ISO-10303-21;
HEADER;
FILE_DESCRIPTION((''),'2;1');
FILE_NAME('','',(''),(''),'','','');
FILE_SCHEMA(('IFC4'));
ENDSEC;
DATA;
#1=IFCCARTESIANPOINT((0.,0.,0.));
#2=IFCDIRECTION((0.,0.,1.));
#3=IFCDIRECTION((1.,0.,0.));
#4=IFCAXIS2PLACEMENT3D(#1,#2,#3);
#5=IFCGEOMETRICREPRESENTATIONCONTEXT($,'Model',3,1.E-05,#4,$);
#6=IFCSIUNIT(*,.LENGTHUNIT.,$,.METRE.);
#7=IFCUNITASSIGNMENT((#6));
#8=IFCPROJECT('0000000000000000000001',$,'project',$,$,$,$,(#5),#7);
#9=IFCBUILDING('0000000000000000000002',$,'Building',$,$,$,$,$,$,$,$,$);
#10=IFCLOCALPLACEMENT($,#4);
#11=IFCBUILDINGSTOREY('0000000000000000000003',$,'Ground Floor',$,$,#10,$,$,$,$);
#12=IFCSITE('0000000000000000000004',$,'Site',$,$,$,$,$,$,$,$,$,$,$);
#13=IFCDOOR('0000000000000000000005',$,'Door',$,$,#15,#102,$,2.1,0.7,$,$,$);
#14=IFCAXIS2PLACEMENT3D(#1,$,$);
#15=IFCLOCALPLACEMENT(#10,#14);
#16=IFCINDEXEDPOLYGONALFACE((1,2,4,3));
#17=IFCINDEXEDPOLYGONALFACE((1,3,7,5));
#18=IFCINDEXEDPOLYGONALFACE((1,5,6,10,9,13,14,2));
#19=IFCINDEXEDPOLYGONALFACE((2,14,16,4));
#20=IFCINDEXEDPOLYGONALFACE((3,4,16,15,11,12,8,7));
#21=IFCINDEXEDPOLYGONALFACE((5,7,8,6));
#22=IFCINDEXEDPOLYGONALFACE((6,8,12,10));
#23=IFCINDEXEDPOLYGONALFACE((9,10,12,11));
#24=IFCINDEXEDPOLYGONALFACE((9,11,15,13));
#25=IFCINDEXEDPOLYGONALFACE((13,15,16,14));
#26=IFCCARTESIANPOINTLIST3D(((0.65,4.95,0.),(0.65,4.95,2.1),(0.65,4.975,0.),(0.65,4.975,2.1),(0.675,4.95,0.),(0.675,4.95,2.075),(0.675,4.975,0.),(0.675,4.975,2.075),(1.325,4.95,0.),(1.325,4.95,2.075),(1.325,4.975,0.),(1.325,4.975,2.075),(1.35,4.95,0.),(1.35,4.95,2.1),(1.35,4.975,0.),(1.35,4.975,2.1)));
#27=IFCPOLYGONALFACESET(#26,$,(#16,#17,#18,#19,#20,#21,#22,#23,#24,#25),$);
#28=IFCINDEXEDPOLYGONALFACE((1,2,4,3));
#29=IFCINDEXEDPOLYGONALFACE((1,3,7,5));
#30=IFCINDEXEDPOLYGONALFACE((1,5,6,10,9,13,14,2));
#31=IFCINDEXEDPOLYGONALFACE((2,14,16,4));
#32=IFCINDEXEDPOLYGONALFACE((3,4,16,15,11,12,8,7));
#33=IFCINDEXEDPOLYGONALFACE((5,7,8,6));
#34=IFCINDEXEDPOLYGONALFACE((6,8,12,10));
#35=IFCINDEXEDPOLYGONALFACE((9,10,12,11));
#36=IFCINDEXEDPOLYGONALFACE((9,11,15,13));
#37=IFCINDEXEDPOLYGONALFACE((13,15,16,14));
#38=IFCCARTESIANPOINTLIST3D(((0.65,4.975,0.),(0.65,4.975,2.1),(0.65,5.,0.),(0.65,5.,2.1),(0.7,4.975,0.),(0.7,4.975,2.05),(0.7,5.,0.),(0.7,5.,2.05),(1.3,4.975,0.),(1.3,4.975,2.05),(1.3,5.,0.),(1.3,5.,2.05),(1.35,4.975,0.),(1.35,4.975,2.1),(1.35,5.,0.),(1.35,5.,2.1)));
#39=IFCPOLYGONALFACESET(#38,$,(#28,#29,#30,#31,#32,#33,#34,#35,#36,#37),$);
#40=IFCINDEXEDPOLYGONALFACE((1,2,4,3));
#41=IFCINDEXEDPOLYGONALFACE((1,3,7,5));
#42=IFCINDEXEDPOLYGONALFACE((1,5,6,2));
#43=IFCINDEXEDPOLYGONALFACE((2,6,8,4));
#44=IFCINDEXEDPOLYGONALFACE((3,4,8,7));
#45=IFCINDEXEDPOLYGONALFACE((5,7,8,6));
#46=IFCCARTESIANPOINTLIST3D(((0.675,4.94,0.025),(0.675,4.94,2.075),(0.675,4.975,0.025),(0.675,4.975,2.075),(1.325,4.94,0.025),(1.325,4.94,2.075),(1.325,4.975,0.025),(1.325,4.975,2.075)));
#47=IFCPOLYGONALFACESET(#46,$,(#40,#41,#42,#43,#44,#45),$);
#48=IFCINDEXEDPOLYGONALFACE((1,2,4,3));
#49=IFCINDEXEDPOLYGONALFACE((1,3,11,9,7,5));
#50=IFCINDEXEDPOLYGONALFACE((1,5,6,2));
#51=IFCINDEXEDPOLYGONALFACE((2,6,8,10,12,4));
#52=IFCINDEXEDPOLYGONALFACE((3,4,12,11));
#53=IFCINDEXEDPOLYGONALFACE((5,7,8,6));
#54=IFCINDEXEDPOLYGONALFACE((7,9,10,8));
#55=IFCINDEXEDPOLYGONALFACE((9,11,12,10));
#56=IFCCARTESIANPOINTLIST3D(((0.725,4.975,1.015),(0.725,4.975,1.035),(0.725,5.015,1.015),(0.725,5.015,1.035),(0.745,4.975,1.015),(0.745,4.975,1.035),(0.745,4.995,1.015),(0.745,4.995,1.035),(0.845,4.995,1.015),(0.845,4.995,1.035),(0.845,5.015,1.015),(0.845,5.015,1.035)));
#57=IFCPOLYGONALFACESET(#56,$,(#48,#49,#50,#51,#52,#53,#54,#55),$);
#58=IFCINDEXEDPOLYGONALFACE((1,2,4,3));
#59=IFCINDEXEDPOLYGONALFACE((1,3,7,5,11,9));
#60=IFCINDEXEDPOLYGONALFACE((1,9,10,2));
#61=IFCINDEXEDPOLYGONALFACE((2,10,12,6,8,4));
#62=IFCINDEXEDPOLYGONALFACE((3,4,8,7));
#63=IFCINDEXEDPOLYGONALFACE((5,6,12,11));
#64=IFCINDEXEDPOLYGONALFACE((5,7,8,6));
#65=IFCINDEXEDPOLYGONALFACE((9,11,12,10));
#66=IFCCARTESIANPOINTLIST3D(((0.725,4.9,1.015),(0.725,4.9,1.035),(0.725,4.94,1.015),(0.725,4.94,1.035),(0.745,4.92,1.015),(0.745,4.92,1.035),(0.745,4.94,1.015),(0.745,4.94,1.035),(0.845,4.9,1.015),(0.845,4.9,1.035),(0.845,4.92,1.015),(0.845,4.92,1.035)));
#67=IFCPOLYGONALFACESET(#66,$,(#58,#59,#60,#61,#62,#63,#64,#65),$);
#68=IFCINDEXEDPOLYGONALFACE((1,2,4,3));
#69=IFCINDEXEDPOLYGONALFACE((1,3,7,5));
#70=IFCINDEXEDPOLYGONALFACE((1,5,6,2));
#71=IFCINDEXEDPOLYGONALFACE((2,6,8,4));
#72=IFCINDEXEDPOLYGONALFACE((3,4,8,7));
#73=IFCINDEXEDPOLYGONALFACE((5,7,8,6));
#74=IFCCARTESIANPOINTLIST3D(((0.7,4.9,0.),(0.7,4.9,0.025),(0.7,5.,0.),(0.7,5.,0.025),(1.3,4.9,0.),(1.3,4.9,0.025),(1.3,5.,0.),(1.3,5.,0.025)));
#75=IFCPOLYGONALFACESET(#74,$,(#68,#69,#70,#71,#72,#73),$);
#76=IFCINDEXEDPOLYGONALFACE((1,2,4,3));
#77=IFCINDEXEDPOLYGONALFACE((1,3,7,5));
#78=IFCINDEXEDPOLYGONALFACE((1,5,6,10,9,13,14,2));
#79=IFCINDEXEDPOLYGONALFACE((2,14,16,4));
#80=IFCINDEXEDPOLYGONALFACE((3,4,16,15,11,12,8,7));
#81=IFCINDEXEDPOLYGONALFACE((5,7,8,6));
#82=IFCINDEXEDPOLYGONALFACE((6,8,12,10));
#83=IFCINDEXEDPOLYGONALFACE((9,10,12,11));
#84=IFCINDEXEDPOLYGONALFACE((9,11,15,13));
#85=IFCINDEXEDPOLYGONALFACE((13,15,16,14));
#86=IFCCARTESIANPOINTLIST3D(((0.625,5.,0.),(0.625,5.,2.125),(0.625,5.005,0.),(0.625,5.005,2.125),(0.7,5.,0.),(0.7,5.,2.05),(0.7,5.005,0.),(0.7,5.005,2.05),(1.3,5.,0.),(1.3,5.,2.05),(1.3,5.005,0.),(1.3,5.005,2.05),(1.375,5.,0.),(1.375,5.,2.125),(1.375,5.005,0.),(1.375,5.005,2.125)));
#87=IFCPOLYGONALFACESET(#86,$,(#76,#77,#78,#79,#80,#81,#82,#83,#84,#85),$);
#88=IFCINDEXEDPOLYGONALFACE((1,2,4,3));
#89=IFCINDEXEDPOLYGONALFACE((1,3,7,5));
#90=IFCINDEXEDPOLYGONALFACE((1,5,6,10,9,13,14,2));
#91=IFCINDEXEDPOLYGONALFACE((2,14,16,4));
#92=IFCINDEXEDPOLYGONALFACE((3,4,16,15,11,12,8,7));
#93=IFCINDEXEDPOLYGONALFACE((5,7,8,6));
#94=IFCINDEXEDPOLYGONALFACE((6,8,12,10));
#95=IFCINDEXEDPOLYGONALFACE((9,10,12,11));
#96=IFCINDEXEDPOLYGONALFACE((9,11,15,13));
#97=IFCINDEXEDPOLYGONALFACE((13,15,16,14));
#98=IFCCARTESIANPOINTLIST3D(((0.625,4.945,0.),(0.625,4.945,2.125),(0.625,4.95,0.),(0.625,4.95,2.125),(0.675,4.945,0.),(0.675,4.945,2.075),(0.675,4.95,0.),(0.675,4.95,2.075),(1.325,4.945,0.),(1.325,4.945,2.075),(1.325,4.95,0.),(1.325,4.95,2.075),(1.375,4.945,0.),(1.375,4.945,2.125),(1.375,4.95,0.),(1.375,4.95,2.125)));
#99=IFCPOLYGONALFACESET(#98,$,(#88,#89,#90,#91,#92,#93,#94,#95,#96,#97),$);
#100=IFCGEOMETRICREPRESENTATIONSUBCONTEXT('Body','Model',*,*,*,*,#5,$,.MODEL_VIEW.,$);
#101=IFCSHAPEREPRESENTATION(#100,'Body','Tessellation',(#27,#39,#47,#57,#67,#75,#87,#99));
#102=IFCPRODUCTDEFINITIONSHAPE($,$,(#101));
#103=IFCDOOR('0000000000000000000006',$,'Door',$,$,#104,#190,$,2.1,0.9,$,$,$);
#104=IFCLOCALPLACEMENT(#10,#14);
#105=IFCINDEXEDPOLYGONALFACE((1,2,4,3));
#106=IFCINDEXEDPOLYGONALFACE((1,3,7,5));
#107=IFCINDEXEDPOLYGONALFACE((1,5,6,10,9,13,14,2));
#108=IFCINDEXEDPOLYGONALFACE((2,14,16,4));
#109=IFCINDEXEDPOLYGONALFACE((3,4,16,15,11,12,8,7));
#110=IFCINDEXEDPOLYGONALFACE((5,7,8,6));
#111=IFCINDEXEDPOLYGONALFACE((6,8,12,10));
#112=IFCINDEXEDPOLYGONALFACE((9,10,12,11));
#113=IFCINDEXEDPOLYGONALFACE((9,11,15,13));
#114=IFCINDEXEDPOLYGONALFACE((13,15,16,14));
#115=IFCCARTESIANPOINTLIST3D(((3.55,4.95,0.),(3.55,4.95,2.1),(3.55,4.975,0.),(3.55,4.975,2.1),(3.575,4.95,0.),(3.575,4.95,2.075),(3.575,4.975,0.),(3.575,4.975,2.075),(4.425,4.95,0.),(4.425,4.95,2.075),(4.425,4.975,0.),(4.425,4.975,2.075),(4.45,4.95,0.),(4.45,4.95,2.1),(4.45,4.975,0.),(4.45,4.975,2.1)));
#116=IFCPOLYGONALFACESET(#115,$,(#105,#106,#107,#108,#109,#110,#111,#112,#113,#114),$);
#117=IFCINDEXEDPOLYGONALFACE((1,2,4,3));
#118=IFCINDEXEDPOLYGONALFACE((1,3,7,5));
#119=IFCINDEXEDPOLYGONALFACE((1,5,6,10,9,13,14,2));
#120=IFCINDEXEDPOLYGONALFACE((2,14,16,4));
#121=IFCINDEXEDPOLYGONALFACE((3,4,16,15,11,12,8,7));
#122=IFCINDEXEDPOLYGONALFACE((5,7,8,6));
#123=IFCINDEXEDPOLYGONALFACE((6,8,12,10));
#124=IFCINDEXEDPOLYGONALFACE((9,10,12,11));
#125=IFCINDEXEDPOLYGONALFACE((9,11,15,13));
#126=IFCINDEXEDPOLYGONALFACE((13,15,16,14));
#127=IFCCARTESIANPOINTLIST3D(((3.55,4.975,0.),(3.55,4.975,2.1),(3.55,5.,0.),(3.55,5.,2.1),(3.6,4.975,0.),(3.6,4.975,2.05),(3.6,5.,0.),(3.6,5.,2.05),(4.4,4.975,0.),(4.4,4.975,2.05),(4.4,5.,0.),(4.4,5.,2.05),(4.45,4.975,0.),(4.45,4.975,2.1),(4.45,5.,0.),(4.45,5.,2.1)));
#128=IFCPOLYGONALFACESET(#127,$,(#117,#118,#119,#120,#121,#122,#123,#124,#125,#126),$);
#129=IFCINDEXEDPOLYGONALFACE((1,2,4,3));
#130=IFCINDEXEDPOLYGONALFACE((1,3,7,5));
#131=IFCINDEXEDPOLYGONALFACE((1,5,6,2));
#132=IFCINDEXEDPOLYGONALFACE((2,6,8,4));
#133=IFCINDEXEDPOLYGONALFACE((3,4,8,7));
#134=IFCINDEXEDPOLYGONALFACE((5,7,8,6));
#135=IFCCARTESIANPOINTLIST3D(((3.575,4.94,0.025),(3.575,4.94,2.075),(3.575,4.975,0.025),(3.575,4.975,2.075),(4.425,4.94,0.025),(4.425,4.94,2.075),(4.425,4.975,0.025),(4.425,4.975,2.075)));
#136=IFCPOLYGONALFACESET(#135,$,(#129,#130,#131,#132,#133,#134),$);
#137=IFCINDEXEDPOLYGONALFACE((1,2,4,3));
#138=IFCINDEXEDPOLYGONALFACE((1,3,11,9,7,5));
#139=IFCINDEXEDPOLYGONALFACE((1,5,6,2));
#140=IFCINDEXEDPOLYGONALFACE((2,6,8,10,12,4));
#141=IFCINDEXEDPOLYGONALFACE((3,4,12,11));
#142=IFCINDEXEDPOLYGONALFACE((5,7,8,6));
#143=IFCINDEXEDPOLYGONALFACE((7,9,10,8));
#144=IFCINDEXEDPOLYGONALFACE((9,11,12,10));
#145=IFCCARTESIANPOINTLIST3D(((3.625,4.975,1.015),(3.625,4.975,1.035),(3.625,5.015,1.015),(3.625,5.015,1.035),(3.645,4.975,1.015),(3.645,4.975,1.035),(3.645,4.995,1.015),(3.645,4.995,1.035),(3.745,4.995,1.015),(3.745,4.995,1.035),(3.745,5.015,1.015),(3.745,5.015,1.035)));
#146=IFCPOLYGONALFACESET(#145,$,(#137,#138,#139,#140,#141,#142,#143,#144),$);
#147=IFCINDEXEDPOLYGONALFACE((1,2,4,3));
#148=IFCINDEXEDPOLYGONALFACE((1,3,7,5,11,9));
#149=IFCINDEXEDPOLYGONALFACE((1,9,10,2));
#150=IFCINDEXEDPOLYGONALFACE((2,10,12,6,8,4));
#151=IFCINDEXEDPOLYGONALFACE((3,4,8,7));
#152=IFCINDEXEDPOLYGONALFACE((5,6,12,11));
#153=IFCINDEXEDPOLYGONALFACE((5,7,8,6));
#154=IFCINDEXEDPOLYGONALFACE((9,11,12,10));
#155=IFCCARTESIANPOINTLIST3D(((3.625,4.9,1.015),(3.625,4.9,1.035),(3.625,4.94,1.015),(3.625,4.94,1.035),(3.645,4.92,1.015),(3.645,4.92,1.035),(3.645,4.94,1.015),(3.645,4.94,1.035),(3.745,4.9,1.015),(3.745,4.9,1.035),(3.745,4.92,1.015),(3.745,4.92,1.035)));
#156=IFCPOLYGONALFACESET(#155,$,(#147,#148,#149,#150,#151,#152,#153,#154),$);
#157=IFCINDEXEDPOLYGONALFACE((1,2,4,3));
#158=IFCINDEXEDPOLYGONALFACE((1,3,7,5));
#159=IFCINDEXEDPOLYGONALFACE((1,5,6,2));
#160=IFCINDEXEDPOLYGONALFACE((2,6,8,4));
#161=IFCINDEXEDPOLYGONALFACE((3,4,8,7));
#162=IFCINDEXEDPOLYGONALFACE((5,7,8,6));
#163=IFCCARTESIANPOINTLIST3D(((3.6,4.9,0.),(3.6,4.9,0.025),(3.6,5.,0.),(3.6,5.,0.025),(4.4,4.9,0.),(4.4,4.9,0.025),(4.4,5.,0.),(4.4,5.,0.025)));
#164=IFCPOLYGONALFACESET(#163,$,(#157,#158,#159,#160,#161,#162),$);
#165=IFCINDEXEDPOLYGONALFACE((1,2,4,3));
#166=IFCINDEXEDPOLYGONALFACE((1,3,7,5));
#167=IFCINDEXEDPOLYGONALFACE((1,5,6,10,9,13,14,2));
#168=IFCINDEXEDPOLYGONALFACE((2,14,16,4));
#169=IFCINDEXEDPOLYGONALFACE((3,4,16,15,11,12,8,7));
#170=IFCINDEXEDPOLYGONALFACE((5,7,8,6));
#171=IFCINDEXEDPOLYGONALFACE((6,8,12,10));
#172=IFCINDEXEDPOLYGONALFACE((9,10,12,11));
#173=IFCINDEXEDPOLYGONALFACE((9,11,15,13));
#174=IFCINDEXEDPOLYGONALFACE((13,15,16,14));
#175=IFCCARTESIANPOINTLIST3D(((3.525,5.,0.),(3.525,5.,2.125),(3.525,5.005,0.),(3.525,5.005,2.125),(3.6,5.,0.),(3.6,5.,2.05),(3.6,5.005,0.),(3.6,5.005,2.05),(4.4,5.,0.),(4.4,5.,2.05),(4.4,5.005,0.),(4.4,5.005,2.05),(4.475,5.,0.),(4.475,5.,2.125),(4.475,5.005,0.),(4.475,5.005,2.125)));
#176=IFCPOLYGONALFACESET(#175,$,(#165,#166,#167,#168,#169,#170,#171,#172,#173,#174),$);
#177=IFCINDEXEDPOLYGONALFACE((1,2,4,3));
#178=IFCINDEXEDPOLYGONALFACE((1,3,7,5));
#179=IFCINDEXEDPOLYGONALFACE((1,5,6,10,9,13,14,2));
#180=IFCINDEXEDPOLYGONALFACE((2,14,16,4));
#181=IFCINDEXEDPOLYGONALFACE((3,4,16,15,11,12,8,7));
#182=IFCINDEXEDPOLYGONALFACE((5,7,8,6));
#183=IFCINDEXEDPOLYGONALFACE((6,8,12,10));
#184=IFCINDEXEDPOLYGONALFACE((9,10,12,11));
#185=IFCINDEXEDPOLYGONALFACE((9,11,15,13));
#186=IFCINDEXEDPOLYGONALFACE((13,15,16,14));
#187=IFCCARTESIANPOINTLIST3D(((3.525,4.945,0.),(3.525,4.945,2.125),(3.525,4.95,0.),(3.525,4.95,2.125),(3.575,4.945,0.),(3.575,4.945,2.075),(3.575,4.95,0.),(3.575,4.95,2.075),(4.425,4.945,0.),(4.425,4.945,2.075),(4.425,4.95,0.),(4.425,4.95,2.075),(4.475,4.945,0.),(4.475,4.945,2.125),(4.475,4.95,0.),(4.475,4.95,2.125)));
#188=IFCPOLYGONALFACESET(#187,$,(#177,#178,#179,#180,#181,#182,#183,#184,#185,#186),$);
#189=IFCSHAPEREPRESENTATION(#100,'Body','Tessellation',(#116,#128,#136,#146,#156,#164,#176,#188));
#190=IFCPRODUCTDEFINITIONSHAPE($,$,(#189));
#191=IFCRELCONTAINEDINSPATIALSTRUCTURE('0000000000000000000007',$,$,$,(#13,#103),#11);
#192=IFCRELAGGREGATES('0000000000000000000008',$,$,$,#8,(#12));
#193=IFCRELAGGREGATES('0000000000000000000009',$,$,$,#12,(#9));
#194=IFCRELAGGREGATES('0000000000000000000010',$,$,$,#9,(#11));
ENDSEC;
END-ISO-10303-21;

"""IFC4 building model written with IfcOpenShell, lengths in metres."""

from ifc_helpers import new_model, si_unit, frame, origin_with_axes, place, context, subcontext, project, spatial, line, indexed_curve, outline, extrude, element, save


model = new_model("IFC4")

# Units and contexts
model_context = context("Model", 3, precision=1e-05, world=origin_with_axes())
body_context = subcontext(model_context, "Body", "Model", "MODEL_VIEW")
ifc_project = project(units=[si_unit("LENGTHUNIT", "METRE")], contexts=[model_context])

# Site, building, storey
site = spatial("IfcSite", under=ifc_project, Name="Site")
building = spatial("IfcBuilding", under=site, Name="Building")
storey_placement = place(None, origin_with_axes())
storey = spatial("IfcBuildingStorey", under=building, at=storey_placement, Name="Ground Floor")

# Doors
door_1_placement = place(storey_placement, frame((1.35, 5.0, 0.0), z_axis=(0.0, 0.0, 1.0), x_axis=(-1.0, 0.0, 0.0)))
element("IfcDoor", 1, at=door_1_placement, inside=storey, Name="Door", OverallHeight=2.1, OverallWidth=0.7, context=body_context, shape_type="SweptSolid", body=[
    extrude(outline(indexed_curve([(0.0, 0.0), (0.0, 2.1), (0.7, 2.1), (0.7, 0.0), (0.675, 0.0), (0.675, 2.075), (0.025, 2.075), (0.025, 0.0)], segments=[line(1, 2, 3, 4, 5, 6, 7, 8, 1)])), frame((0.0, 0.025, 0.0), z_axis=(0.0, -1.0, 0.0), x_axis=(1.0, 0.0, 0.0)), (0.0, 0.0, -1.0), 0.025),
    extrude(outline(indexed_curve([(0.0, 0.0), (0.0, 2.1), (0.7, 2.1), (0.7, 0.0), (0.65, 0.0), (0.65, 2.05), (0.05, 2.05), (0.05, 0.0)], segments=[line(1, 2, 3, 4, 5, 6, 7, 8, 1)])), frame((0.0, 0.0, 0.0), z_axis=(0.0, -1.0, 0.0), x_axis=(1.0, 0.0, 0.0)), (0.0, 0.0, -1.0), 0.025),
    extrude(outline(indexed_curve([(0.0, 0.0), (0.65, 0.0), (0.65, 0.035), (0.0, 0.035)], segments=[line(1, 2, 3, 4, 1)])), frame((0.025, 0.025, 0.025), z_axis=(0.0, 0.0, 1.0), x_axis=(1.0, 0.0, 0.0)), (0.0, 0.0, 1.0), 2.05),
    extrude(outline(indexed_curve([(0.0, 0.0), (0.0, -0.04), (-0.12, -0.04), (-0.12, -0.02), (-0.02, -0.02), (-0.02, 0.0)], segments=[line(1, 2, 3, 4, 5, 6, 1)])), frame((0.625, 0.025, 1.015), z_axis=(0.0, 0.0, 1.0), x_axis=(1.0, 0.0, 0.0)), (0.0, 0.0, 1.0), 0.02),
    extrude(outline(indexed_curve([(0.0, 0.0), (0.0, 0.04), (-0.12, 0.04), (-0.12, 0.02), (-0.02, 0.02), (-0.02, 0.0)], segments=[line(1, 2, 3, 4, 5, 6, 1)])), frame((0.625, 0.06, 1.015), z_axis=(0.0, 0.0, 1.0), x_axis=(1.0, 0.0, 0.0)), (0.0, 0.0, 1.0), 0.02),
    extrude(outline(indexed_curve([(0.0, 0.0), (0.6, 0.0), (0.6, 0.1), (0.0, 0.1)], segments=[line(1, 2, 3, 4, 1)])), frame((0.05, 0.0, 0.0), z_axis=(0.0, 0.0, 1.0), x_axis=(1.0, 0.0, 0.0)), (0.0, 0.0, 1.0), 0.025),
    extrude(outline(indexed_curve([(0.0, 0.0), (0.0, 2.125), (0.75, 2.125), (0.75, 0.0), (0.675, 0.0), (0.675, 2.05), (0.075, 2.05), (0.075, 0.0)], segments=[line(1, 2, 3, 4, 5, 6, 7, 8, 1)])), frame((-0.025, -0.005, 0.0), z_axis=(0.0, -1.0, 0.0), x_axis=(1.0, 0.0, 0.0)), (0.0, 0.0, -1.0), 0.005),
    extrude(outline(indexed_curve([(0.0, 0.0), (0.0, 2.125), (0.75, 2.125), (0.75, 0.0), (0.7, 0.0), (0.7, 2.075), (0.05, 2.075), (0.05, 0.0)], segments=[line(1, 2, 3, 4, 5, 6, 7, 8, 1)])), frame((-0.025, 0.05, 0.0), z_axis=(0.0, -1.0, 0.0), x_axis=(1.0, 0.0, 0.0)), (0.0, 0.0, -1.0), 0.005),
])
door_2_placement = place(storey_placement, frame((4.45, 5.0, 0.0), z_axis=(0.0, 0.0, 1.0), x_axis=(-1.0, 0.0, 0.0)))
element("IfcDoor", 2, at=door_2_placement, inside=storey, Name="Door", OverallHeight=2.1, OverallWidth=0.9, context=body_context, shape_type="SweptSolid", body=[
    extrude(outline(indexed_curve([(0.0, 0.0), (0.0, 2.1), (0.9, 2.1), (0.9, 0.0), (0.875, 0.0), (0.875, 2.075), (0.025, 2.075), (0.025, 0.0)], segments=[line(1, 2, 3, 4, 5, 6, 7, 8, 1)])), frame((0.0, 0.025, 0.0), z_axis=(0.0, -1.0, 0.0), x_axis=(1.0, 0.0, 0.0)), (0.0, 0.0, -1.0), 0.025),
    extrude(outline(indexed_curve([(0.0, 0.0), (0.0, 2.1), (0.9, 2.1), (0.9, 0.0), (0.85, 0.0), (0.85, 2.05), (0.05, 2.05), (0.05, 0.0)], segments=[line(1, 2, 3, 4, 5, 6, 7, 8, 1)])), frame((0.0, 0.0, 0.0), z_axis=(0.0, -1.0, 0.0), x_axis=(1.0, 0.0, 0.0)), (0.0, 0.0, -1.0), 0.025),
    extrude(outline(indexed_curve([(0.0, 0.0), (0.85, 0.0), (0.85, 0.035), (0.0, 0.035)], segments=[line(1, 2, 3, 4, 1)])), frame((0.025, 0.025, 0.025), z_axis=(0.0, 0.0, 1.0), x_axis=(1.0, 0.0, 0.0)), (0.0, 0.0, 1.0), 2.05),
    extrude(outline(indexed_curve([(0.0, 0.0), (0.0, -0.04), (-0.12, -0.04), (-0.12, -0.02), (-0.02, -0.02), (-0.02, 0.0)], segments=[line(1, 2, 3, 4, 5, 6, 1)])), frame((0.825, 0.025, 1.015), z_axis=(0.0, 0.0, 1.0), x_axis=(1.0, 0.0, 0.0)), (0.0, 0.0, 1.0), 0.02),
    extrude(outline(indexed_curve([(0.0, 0.0), (0.0, 0.04), (-0.12, 0.04), (-0.12, 0.02), (-0.02, 0.02), (-0.02, 0.0)], segments=[line(1, 2, 3, 4, 5, 6, 1)])), frame((0.825, 0.06, 1.015), z_axis=(0.0, 0.0, 1.0), x_axis=(1.0, 0.0, 0.0)), (0.0, 0.0, 1.0), 0.02),
    extrude(outline(indexed_curve([(0.0, 0.0), (0.8, 0.0), (0.8, 0.1), (0.0, 0.1)], segments=[line(1, 2, 3, 4, 1)])), frame((0.05, 0.0, 0.0), z_axis=(0.0, 0.0, 1.0), x_axis=(1.0, 0.0, 0.0)), (0.0, 0.0, 1.0), 0.025),
    extrude(outline(indexed_curve([(0.0, 0.0), (0.0, 2.125), (0.95, 2.125), (0.95, 0.0), (0.875, 0.0), (0.875, 2.05), (0.075, 2.05), (0.075, 0.0)], segments=[line(1, 2, 3, 4, 5, 6, 7, 8, 1)])), frame((-0.025, -0.005, 0.0), z_axis=(0.0, -1.0, 0.0), x_axis=(1.0, 0.0, 0.0)), (0.0, 0.0, -1.0), 0.005),
    extrude(outline(indexed_curve([(0.0, 0.0), (0.0, 2.125), (0.95, 2.125), (0.95, 0.0), (0.9, 0.0), (0.9, 2.075), (0.05, 2.075), (0.05, 0.0)], segments=[line(1, 2, 3, 4, 5, 6, 7, 8, 1)])), frame((-0.025, 0.05, 0.0), z_axis=(0.0, -1.0, 0.0), x_axis=(1.0, 0.0, 0.0)), (0.0, 0.0, -1.0), 0.005),
])

save(model, "model.ifc")
